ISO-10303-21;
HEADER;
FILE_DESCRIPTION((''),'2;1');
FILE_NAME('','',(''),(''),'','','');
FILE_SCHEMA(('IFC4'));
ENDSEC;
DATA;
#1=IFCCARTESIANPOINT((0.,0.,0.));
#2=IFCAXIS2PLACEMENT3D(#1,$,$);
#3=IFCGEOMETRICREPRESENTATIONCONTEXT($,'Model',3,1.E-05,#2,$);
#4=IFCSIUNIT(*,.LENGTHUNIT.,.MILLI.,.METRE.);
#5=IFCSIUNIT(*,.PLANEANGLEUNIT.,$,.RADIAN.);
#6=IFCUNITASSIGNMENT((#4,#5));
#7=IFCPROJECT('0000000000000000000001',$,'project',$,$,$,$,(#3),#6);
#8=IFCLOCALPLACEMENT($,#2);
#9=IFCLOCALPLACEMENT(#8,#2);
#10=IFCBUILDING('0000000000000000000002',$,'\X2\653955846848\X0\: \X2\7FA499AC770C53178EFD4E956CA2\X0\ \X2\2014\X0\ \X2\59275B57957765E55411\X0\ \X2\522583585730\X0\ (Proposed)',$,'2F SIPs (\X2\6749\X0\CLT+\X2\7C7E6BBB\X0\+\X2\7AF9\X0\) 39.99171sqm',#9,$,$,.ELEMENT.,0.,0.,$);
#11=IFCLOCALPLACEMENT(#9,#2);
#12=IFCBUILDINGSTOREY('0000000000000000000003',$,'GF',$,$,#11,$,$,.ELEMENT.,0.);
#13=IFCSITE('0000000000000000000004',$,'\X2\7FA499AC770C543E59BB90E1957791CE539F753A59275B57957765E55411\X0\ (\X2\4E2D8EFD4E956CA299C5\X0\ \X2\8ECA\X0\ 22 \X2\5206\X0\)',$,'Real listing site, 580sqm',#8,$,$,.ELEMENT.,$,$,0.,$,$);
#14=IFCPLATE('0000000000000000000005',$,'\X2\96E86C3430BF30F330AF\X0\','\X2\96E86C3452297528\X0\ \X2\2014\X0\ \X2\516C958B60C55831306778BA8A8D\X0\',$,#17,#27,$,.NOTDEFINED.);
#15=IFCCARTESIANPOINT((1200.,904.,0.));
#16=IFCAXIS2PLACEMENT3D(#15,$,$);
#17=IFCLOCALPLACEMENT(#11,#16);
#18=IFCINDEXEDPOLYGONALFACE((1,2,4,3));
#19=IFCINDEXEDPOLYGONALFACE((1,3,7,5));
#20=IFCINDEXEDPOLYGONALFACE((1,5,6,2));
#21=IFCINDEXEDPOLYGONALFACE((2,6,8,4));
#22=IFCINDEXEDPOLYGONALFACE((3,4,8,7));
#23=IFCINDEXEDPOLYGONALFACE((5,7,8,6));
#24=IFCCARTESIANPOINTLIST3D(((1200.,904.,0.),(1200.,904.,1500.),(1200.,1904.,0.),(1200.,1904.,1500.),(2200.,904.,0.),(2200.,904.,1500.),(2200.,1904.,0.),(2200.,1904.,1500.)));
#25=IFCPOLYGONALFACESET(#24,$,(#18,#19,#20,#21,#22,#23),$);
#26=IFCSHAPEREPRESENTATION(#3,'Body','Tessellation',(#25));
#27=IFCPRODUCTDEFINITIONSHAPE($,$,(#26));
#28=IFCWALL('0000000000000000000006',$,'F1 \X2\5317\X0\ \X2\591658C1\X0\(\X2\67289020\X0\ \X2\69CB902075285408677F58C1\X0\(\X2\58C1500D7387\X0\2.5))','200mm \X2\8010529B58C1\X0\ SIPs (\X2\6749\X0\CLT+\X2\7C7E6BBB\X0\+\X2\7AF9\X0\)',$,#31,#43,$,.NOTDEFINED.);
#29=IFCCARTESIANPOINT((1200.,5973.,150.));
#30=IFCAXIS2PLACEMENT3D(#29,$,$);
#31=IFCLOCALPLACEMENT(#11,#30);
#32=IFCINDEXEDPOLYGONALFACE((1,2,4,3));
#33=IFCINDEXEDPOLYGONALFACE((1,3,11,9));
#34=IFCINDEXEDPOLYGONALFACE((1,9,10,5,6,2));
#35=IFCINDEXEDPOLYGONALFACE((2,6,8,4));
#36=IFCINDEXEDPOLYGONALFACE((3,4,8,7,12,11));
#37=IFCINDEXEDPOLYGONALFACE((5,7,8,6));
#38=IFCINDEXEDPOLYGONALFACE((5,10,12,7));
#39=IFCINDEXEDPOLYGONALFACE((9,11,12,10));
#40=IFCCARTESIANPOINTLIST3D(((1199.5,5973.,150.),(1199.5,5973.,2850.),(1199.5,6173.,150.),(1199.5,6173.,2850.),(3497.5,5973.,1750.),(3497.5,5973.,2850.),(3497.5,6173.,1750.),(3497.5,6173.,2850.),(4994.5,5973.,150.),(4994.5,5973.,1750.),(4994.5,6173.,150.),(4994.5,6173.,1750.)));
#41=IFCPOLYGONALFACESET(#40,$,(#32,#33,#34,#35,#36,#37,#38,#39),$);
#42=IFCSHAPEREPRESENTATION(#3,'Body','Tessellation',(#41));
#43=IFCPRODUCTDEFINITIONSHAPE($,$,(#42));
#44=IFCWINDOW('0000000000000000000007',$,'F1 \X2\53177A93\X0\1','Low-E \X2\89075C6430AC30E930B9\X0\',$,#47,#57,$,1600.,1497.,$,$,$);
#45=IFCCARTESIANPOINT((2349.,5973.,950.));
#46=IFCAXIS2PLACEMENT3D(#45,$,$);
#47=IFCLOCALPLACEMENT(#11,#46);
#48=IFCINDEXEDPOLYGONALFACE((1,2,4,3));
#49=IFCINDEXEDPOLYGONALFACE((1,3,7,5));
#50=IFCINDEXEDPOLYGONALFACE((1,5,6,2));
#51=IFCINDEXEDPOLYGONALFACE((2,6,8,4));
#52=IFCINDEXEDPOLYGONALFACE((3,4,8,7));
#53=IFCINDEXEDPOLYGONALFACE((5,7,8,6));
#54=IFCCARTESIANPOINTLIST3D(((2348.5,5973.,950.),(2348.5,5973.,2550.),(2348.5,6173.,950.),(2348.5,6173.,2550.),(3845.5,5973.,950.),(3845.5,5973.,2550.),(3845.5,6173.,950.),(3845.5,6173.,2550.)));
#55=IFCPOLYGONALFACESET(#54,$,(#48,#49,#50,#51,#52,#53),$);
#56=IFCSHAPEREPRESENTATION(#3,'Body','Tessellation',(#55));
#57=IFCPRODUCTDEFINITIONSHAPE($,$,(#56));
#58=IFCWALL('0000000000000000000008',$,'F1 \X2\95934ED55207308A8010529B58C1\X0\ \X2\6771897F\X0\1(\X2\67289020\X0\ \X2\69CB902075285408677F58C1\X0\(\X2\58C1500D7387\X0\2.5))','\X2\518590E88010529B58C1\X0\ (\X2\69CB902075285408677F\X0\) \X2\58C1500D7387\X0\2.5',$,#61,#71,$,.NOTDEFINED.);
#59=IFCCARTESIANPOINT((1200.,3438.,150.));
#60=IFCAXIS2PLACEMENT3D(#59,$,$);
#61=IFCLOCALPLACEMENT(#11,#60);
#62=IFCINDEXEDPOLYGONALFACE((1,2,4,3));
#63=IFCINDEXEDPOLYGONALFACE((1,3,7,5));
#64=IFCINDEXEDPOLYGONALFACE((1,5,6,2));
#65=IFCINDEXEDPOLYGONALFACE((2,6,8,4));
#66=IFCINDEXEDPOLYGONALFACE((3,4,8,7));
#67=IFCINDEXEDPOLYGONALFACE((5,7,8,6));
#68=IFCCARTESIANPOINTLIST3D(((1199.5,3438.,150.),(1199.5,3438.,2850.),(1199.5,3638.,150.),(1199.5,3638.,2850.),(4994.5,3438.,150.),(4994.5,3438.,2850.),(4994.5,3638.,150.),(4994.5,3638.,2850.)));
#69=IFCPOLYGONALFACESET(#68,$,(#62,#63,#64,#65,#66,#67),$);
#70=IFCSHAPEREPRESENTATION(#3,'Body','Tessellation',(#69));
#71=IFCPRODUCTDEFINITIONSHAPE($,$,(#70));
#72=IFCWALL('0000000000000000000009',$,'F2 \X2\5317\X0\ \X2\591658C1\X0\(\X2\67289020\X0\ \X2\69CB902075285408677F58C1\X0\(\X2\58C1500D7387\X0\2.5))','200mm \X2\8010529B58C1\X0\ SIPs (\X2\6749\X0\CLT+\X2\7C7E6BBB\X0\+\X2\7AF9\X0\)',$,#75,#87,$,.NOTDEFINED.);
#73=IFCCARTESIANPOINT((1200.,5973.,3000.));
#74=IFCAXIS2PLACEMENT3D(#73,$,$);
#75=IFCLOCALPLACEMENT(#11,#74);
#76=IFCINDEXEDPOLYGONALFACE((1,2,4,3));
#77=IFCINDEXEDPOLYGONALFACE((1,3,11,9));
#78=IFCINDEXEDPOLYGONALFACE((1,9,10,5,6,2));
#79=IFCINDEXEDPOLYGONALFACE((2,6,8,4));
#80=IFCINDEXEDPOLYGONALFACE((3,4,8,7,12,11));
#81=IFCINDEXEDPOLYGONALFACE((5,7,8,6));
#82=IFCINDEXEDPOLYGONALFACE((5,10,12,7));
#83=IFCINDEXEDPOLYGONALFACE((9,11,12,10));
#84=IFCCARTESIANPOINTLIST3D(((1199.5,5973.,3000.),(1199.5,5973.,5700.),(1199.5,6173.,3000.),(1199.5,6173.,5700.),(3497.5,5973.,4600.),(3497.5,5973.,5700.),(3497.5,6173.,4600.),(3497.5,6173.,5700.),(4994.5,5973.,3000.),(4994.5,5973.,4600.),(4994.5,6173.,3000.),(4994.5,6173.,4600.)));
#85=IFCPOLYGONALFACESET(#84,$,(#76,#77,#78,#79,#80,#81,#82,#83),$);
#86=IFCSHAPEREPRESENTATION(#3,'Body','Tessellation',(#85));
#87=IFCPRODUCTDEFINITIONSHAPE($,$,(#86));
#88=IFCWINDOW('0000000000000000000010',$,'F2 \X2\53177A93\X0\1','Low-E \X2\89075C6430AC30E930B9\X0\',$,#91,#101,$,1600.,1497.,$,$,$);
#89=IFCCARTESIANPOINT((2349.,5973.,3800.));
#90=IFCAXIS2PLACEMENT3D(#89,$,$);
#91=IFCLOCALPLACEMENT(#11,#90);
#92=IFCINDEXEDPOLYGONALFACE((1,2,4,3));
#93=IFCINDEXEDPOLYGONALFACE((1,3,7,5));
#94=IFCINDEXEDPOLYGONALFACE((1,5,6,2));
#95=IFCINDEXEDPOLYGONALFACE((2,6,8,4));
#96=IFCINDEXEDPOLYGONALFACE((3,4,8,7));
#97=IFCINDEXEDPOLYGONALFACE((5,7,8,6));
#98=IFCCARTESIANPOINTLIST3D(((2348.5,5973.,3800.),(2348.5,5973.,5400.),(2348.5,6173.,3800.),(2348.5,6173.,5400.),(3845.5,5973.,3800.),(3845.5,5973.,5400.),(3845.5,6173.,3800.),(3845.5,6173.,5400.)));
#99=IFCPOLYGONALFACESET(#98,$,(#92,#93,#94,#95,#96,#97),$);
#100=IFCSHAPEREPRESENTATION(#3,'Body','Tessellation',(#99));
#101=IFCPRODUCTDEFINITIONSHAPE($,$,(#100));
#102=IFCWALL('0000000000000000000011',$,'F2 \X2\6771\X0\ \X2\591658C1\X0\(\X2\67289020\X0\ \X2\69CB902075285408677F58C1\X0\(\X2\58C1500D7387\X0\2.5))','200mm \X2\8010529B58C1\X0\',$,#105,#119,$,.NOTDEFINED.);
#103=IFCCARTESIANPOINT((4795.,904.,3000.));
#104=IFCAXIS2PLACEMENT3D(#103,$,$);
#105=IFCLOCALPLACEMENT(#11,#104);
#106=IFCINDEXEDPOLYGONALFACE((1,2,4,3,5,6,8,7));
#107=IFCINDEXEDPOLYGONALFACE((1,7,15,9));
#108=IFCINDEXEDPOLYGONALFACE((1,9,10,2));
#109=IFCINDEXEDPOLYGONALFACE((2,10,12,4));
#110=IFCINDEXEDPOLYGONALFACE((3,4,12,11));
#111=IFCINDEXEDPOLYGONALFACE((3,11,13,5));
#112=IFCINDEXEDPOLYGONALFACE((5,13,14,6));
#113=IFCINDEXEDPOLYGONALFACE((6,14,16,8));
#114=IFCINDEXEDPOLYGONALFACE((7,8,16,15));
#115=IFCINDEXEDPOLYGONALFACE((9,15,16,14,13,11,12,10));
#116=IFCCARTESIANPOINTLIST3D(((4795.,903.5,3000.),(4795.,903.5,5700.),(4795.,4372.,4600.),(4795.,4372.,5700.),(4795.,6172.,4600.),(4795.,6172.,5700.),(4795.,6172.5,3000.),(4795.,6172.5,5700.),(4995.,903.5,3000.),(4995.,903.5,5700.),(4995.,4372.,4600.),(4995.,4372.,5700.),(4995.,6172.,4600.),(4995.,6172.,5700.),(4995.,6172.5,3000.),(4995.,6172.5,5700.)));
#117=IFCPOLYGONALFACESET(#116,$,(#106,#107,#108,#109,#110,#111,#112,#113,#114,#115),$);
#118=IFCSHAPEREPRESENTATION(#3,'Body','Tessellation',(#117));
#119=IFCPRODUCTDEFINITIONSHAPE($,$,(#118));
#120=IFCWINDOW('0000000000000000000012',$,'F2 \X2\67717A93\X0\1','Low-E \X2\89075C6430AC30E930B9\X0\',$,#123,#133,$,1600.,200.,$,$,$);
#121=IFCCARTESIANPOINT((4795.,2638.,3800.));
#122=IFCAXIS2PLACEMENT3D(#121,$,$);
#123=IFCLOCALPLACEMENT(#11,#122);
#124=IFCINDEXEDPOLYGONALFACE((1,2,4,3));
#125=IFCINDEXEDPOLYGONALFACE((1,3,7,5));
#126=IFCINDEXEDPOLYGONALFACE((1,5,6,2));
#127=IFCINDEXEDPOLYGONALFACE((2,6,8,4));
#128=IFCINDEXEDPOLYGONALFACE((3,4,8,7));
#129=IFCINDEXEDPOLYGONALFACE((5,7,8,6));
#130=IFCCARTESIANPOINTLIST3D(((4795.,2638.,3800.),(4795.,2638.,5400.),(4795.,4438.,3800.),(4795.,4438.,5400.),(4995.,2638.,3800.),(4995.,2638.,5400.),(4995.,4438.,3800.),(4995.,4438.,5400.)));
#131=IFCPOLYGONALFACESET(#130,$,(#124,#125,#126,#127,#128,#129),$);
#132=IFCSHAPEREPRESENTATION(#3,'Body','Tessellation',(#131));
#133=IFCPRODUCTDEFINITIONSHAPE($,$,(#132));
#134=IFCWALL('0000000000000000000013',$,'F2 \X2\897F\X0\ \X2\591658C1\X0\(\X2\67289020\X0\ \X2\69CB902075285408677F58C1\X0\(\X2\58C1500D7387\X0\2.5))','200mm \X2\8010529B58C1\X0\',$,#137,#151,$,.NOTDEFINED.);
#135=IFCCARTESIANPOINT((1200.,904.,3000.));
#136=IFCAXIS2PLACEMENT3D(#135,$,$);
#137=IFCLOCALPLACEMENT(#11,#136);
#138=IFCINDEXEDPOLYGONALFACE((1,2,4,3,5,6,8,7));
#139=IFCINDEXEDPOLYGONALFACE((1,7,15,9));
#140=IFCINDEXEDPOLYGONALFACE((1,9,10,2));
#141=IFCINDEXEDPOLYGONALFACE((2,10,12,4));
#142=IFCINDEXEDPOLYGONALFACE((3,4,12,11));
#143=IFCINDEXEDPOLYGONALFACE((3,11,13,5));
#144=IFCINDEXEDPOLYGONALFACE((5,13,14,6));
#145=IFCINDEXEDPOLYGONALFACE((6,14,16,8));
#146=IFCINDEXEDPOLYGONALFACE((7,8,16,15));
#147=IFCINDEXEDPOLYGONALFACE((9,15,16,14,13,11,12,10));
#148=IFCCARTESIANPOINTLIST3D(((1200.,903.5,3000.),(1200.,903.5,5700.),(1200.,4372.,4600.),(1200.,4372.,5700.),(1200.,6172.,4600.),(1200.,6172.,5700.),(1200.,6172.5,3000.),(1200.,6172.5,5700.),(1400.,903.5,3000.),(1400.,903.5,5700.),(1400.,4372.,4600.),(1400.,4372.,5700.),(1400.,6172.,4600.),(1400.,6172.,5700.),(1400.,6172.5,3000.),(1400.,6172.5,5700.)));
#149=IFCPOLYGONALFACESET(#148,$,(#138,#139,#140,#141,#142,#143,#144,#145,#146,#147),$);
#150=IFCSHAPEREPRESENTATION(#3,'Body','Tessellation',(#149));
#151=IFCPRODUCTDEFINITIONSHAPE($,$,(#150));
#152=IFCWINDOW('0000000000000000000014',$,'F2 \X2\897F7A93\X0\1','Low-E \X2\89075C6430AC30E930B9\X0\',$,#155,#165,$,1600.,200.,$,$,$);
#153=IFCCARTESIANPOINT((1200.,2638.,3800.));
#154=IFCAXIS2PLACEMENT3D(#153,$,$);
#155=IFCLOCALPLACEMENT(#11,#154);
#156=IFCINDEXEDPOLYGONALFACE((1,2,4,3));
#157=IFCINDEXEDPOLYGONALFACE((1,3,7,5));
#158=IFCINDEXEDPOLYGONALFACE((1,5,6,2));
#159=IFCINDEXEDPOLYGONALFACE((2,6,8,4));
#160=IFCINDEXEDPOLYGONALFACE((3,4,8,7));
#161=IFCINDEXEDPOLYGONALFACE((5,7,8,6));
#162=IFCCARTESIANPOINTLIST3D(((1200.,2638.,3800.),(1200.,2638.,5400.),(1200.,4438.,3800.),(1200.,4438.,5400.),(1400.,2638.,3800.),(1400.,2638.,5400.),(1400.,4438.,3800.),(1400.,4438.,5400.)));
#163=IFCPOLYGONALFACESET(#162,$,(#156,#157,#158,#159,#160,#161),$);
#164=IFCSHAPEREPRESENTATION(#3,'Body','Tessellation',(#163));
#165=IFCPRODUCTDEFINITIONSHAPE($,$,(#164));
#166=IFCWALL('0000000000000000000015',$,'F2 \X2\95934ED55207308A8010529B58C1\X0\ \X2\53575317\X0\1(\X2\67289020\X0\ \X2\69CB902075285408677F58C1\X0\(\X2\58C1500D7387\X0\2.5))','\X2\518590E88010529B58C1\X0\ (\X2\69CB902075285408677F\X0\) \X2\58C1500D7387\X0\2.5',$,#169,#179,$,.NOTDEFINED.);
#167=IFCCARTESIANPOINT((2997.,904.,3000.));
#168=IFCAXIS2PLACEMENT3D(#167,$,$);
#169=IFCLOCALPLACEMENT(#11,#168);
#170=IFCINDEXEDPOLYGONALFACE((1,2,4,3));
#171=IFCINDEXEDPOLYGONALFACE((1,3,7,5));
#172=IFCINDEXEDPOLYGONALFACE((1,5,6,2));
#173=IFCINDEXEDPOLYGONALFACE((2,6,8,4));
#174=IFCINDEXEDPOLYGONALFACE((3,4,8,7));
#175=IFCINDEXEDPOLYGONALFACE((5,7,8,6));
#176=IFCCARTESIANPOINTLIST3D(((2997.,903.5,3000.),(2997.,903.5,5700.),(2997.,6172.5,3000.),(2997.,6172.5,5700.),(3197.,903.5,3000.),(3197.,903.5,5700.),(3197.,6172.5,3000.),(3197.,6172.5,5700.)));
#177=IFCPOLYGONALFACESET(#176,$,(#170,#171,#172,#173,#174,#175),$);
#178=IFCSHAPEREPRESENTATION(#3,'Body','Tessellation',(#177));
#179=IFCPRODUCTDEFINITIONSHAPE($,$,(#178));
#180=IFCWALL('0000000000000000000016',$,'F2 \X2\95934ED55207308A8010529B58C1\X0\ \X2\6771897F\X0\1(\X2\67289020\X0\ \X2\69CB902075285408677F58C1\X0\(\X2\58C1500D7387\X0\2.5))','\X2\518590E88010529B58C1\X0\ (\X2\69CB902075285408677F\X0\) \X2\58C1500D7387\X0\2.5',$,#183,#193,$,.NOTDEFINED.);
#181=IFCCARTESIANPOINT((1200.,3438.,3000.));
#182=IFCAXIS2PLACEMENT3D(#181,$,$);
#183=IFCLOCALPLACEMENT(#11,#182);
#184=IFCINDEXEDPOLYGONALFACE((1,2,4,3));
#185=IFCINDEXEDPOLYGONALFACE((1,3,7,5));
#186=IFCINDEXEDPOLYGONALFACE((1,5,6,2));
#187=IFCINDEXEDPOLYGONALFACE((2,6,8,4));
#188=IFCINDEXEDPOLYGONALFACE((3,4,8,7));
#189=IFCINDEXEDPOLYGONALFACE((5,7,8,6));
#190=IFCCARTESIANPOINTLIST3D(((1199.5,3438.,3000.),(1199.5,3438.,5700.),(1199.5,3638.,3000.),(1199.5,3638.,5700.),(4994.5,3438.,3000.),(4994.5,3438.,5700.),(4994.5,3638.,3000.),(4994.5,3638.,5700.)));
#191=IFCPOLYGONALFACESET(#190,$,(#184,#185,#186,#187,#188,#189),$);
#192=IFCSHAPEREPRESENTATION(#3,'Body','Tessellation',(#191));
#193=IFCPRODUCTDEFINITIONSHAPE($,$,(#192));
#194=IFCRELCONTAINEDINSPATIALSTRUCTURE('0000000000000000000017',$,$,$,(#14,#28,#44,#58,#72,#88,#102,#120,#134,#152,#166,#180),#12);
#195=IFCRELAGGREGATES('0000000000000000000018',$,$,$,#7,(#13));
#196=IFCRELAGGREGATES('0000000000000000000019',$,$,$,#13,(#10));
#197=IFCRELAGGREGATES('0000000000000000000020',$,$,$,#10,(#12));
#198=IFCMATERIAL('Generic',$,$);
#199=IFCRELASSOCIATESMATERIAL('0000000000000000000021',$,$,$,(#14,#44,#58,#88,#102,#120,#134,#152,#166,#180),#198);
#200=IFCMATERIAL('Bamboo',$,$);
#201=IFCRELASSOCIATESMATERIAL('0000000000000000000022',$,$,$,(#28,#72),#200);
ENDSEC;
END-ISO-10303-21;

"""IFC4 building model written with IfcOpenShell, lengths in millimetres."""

from ifc_helpers import new_model, si_unit, frame, frame_2d, origin, place, context, project, spatial, rectangle, extrude, material, element, fill, save


model = new_model("IFC4")

# Units and contexts
model_context = context("Model", 3, precision=1e-05, world=origin())
ifc_project = project(units=[si_unit("LENGTHUNIT", "METRE", prefix="MILLI"), si_unit("PLANEANGLEUNIT", "RADIAN")], contexts=[model_context])

# Site, building, storey
site_placement = place(None, origin())
site = spatial("IfcSite", under=ifc_project, at=site_placement, Name="群馬県吾妻郡長野原町大字長日向 (中軽井沢駅 車 22 分)", ObjectType="Real listing site, 580sqm", CompositionType="ELEMENT", RefElevation=0.0)
building_placement = place(site_placement, origin())
building = spatial("IfcBuilding", under=site, at=building_placement, Name="改善案: 群馬県北軽井沢 — 大字長日向 別荘地 (Proposed)", ObjectType="2F SIPs (杉CLT+籾殻+竹) 39.99171sqm", CompositionType="ELEMENT", ElevationOfRefHeight=0.0, ElevationOfTerrain=0.0)
storey_placement = place(building_placement, origin())
storey = spatial("IfcBuildingStorey", under=building, at=storey_placement, Name="GF", CompositionType="ELEMENT", Elevation=0.0)

# Plate
ifc_material_1 = material(Name="Generic")
plate_placement = place(storey_placement, frame((1200.0, 904.0, 0.0)))
element("IfcPlate", 1, at=plate_placement, inside=storey, material=ifc_material_1, Name="雨水タンク", Description="雨水利用 — 公開情報で確認", PredefinedType="NOTDEFINED", context=model_context, shape_type="SweptSolid", body=[
    extrude(rectangle(XDim=1000.0, YDim=1000.0, at=frame_2d((500.0, 500.0))), frame((1200.0, 904.0, 0.0)), (0.0, 0.0, 1.0), 1500.0),
])

# Wall, opening, window
ifc_material_2 = material(Name="Bamboo")
wall_1_placement = place(storey_placement, frame((1200.0, 5973.0, 150.0)))
wall_1 = element("IfcWall", 2, at=wall_1_placement, inside=storey, material=ifc_material_2, Name="F1 北 外壁(木造 構造用合板壁(壁倍率2.5))", Description="200mm 耐力壁 SIPs (杉CLT+籾殻+竹)", PredefinedType="NOTDEFINED", context=model_context, shape_type="SweptSolid", body=[
    extrude(rectangle(XDim=3795.0, YDim=200.0, at=frame_2d((1897.0, 100.0))), frame((1200.0, 5973.0, 150.0)), (0.0, 0.0, 1.0), 2700.0),
])
opening_1_placement = place(storey_placement, frame((2349.0, 5973.0, 950.0)))
opening_1 = element("IfcOpeningElement", 3, at=opening_1_placement, cuts=wall_1, PredefinedType="NOTDEFINED", context=model_context, shape_type="SweptSolid", body=[
    extrude(rectangle(XDim=1497.0, YDim=200.0, at=frame_2d((748.0, 100.0))), frame((2349.0, 5973.0, 950.0)), (0.0, 0.0, 1.0), 1600.0),
])
window_1_placement = place(storey_placement, frame((2349.0, 5973.0, 950.0)))
window_1 = element("IfcWindow", 4, at=window_1_placement, inside=storey, material=ifc_material_1, Name="F1 北窓1", Description="Low-E 複層ガラス", OverallHeight=1600.0, OverallWidth=1497.0, context=model_context, shape_type="SweptSolid", body=[
    extrude(rectangle(XDim=1497.0, YDim=200.0, at=frame_2d((748.0, 100.0))), frame((2349.0, 5973.0, 950.0)), (0.0, 0.0, 1.0), 1600.0),
])
fill(opening_1, window_1)

# Wall
wall_2_placement = place(storey_placement, frame((1200.0, 3438.0, 150.0)))
element("IfcWall", 5, at=wall_2_placement, inside=storey, material=ifc_material_1, Name="F1 間仕切り耐力壁 東西1(木造 構造用合板壁(壁倍率2.5))", Description="内部耐力壁 (構造用合板) 壁倍率2.5", PredefinedType="NOTDEFINED", context=model_context, shape_type="SweptSolid", body=[
    extrude(rectangle(XDim=3795.0, YDim=200.0, at=frame_2d((1897.0, 100.0))), frame((1200.0, 3438.0, 150.0)), (0.0, 0.0, 1.0), 2700.0),
])

# Walls, openings, windows
wall_3_placement = place(storey_placement, frame((1200.0, 5973.0, 3000.0)))
wall_3 = element("IfcWall", 6, at=wall_3_placement, inside=storey, material=ifc_material_2, Name="F2 北 外壁(木造 構造用合板壁(壁倍率2.5))", Description="200mm 耐力壁 SIPs (杉CLT+籾殻+竹)", PredefinedType="NOTDEFINED", context=model_context, shape_type="SweptSolid", body=[
    extrude(rectangle(XDim=3795.0, YDim=200.0, at=frame_2d((1897.0, 100.0))), frame((1200.0, 5973.0, 3000.0)), (0.0, 0.0, 1.0), 2700.0),
])
opening_2_placement = place(storey_placement, frame((2349.0, 5973.0, 3800.0)))
opening_2 = element("IfcOpeningElement", 7, at=opening_2_placement, cuts=wall_3, PredefinedType="NOTDEFINED", context=model_context, shape_type="SweptSolid", body=[
    extrude(rectangle(XDim=1497.0, YDim=200.0, at=frame_2d((748.0, 100.0))), frame((2349.0, 5973.0, 3800.0)), (0.0, 0.0, 1.0), 1600.0),
])
window_2_placement = place(storey_placement, frame((2349.0, 5973.0, 3800.0)))
window_2 = element("IfcWindow", 8, at=window_2_placement, inside=storey, material=ifc_material_1, Name="F2 北窓1", Description="Low-E 複層ガラス", OverallHeight=1600.0, OverallWidth=1497.0, context=model_context, shape_type="SweptSolid", body=[
    extrude(rectangle(XDim=1497.0, YDim=200.0, at=frame_2d((748.0, 100.0))), frame((2349.0, 5973.0, 3800.0)), (0.0, 0.0, 1.0), 1600.0),
])
fill(opening_2, window_2)
wall_4_placement = place(storey_placement, frame((4795.0, 904.0, 3000.0)))
wall_4 = element("IfcWall", 9, at=wall_4_placement, inside=storey, material=ifc_material_1, Name="F2 東 外壁(木造 構造用合板壁(壁倍率2.5))", Description="200mm 耐力壁", PredefinedType="NOTDEFINED", context=model_context, shape_type="SweptSolid", body=[
    extrude(rectangle(XDim=200.0, YDim=5269.0, at=frame_2d((100.0, 2634.0))), frame((4795.0, 904.0, 3000.0)), (0.0, 0.0, 1.0), 2700.0),
])
opening_3_placement = place(storey_placement, frame((4795.0, 2638.0, 3800.0)))
opening_3 = element("IfcOpeningElement", 10, at=opening_3_placement, cuts=wall_4, PredefinedType="NOTDEFINED", context=model_context, shape_type="SweptSolid", body=[
    extrude(rectangle(XDim=200.0, YDim=1800.0, at=frame_2d((100.0, 900.0))), frame((4795.0, 2638.0, 3800.0)), (0.0, 0.0, 1.0), 1600.0),
])
window_3_placement = place(storey_placement, frame((4795.0, 2638.0, 3800.0)))
window_3 = element("IfcWindow", 11, at=window_3_placement, inside=storey, material=ifc_material_1, Name="F2 東窓1", Description="Low-E 複層ガラス", OverallHeight=1600.0, OverallWidth=200.0, context=model_context, shape_type="SweptSolid", body=[
    extrude(rectangle(XDim=200.0, YDim=1800.0, at=frame_2d((100.0, 900.0))), frame((4795.0, 2638.0, 3800.0)), (0.0, 0.0, 1.0), 1600.0),
])
fill(opening_3, window_3)
wall_5_placement = place(storey_placement, frame((1200.0, 904.0, 3000.0)))
wall_5 = element("IfcWall", 12, at=wall_5_placement, inside=storey, material=ifc_material_1, Name="F2 西 外壁(木造 構造用合板壁(壁倍率2.5))", Description="200mm 耐力壁", PredefinedType="NOTDEFINED", context=model_context, shape_type="SweptSolid", body=[
    extrude(rectangle(XDim=200.0, YDim=5269.0, at=frame_2d((100.0, 2634.0))), frame((1200.0, 904.0, 3000.0)), (0.0, 0.0, 1.0), 2700.0),
])
opening_4_placement = place(storey_placement, frame((1200.0, 2638.0, 3800.0)))
opening_4 = element("IfcOpeningElement", 13, at=opening_4_placement, cuts=wall_5, PredefinedType="NOTDEFINED", context=model_context, shape_type="SweptSolid", body=[
    extrude(rectangle(XDim=200.0, YDim=1800.0, at=frame_2d((100.0, 900.0))), frame((1200.0, 2638.0, 3800.0)), (0.0, 0.0, 1.0), 1600.0),
])
window_4_placement = place(storey_placement, frame((1200.0, 2638.0, 3800.0)))
window_4 = element("IfcWindow", 14, at=window_4_placement, inside=storey, material=ifc_material_1, Name="F2 西窓1", Description="Low-E 複層ガラス", OverallHeight=1600.0, OverallWidth=200.0, context=model_context, shape_type="SweptSolid", body=[
    extrude(rectangle(XDim=200.0, YDim=1800.0, at=frame_2d((100.0, 900.0))), frame((1200.0, 2638.0, 3800.0)), (0.0, 0.0, 1.0), 1600.0),
])
fill(opening_4, window_4)

# Walls
wall_6_placement = place(storey_placement, frame((2997.0, 904.0, 3000.0)))
element("IfcWall", 15, at=wall_6_placement, inside=storey, material=ifc_material_1, Name="F2 間仕切り耐力壁 南北1(木造 構造用合板壁(壁倍率2.5))", Description="内部耐力壁 (構造用合板) 壁倍率2.5", PredefinedType="NOTDEFINED", context=model_context, shape_type="SweptSolid", body=[
    extrude(rectangle(XDim=200.0, YDim=5269.0, at=frame_2d((100.0, 2634.0))), frame((2997.0, 904.0, 3000.0)), (0.0, 0.0, 1.0), 2700.0),
])
wall_7_placement = place(storey_placement, frame((1200.0, 3438.0, 3000.0)))
element("IfcWall", 16, at=wall_7_placement, inside=storey, material=ifc_material_1, Name="F2 間仕切り耐力壁 東西1(木造 構造用合板壁(壁倍率2.5))", Description="内部耐力壁 (構造用合板) 壁倍率2.5", PredefinedType="NOTDEFINED", context=model_context, shape_type="SweptSolid", body=[
    extrude(rectangle(XDim=3795.0, YDim=200.0, at=frame_2d((1897.0, 100.0))), frame((1200.0, 3438.0, 3000.0)), (0.0, 0.0, 1.0), 2700.0),
])

save(model, "model.ifc")
